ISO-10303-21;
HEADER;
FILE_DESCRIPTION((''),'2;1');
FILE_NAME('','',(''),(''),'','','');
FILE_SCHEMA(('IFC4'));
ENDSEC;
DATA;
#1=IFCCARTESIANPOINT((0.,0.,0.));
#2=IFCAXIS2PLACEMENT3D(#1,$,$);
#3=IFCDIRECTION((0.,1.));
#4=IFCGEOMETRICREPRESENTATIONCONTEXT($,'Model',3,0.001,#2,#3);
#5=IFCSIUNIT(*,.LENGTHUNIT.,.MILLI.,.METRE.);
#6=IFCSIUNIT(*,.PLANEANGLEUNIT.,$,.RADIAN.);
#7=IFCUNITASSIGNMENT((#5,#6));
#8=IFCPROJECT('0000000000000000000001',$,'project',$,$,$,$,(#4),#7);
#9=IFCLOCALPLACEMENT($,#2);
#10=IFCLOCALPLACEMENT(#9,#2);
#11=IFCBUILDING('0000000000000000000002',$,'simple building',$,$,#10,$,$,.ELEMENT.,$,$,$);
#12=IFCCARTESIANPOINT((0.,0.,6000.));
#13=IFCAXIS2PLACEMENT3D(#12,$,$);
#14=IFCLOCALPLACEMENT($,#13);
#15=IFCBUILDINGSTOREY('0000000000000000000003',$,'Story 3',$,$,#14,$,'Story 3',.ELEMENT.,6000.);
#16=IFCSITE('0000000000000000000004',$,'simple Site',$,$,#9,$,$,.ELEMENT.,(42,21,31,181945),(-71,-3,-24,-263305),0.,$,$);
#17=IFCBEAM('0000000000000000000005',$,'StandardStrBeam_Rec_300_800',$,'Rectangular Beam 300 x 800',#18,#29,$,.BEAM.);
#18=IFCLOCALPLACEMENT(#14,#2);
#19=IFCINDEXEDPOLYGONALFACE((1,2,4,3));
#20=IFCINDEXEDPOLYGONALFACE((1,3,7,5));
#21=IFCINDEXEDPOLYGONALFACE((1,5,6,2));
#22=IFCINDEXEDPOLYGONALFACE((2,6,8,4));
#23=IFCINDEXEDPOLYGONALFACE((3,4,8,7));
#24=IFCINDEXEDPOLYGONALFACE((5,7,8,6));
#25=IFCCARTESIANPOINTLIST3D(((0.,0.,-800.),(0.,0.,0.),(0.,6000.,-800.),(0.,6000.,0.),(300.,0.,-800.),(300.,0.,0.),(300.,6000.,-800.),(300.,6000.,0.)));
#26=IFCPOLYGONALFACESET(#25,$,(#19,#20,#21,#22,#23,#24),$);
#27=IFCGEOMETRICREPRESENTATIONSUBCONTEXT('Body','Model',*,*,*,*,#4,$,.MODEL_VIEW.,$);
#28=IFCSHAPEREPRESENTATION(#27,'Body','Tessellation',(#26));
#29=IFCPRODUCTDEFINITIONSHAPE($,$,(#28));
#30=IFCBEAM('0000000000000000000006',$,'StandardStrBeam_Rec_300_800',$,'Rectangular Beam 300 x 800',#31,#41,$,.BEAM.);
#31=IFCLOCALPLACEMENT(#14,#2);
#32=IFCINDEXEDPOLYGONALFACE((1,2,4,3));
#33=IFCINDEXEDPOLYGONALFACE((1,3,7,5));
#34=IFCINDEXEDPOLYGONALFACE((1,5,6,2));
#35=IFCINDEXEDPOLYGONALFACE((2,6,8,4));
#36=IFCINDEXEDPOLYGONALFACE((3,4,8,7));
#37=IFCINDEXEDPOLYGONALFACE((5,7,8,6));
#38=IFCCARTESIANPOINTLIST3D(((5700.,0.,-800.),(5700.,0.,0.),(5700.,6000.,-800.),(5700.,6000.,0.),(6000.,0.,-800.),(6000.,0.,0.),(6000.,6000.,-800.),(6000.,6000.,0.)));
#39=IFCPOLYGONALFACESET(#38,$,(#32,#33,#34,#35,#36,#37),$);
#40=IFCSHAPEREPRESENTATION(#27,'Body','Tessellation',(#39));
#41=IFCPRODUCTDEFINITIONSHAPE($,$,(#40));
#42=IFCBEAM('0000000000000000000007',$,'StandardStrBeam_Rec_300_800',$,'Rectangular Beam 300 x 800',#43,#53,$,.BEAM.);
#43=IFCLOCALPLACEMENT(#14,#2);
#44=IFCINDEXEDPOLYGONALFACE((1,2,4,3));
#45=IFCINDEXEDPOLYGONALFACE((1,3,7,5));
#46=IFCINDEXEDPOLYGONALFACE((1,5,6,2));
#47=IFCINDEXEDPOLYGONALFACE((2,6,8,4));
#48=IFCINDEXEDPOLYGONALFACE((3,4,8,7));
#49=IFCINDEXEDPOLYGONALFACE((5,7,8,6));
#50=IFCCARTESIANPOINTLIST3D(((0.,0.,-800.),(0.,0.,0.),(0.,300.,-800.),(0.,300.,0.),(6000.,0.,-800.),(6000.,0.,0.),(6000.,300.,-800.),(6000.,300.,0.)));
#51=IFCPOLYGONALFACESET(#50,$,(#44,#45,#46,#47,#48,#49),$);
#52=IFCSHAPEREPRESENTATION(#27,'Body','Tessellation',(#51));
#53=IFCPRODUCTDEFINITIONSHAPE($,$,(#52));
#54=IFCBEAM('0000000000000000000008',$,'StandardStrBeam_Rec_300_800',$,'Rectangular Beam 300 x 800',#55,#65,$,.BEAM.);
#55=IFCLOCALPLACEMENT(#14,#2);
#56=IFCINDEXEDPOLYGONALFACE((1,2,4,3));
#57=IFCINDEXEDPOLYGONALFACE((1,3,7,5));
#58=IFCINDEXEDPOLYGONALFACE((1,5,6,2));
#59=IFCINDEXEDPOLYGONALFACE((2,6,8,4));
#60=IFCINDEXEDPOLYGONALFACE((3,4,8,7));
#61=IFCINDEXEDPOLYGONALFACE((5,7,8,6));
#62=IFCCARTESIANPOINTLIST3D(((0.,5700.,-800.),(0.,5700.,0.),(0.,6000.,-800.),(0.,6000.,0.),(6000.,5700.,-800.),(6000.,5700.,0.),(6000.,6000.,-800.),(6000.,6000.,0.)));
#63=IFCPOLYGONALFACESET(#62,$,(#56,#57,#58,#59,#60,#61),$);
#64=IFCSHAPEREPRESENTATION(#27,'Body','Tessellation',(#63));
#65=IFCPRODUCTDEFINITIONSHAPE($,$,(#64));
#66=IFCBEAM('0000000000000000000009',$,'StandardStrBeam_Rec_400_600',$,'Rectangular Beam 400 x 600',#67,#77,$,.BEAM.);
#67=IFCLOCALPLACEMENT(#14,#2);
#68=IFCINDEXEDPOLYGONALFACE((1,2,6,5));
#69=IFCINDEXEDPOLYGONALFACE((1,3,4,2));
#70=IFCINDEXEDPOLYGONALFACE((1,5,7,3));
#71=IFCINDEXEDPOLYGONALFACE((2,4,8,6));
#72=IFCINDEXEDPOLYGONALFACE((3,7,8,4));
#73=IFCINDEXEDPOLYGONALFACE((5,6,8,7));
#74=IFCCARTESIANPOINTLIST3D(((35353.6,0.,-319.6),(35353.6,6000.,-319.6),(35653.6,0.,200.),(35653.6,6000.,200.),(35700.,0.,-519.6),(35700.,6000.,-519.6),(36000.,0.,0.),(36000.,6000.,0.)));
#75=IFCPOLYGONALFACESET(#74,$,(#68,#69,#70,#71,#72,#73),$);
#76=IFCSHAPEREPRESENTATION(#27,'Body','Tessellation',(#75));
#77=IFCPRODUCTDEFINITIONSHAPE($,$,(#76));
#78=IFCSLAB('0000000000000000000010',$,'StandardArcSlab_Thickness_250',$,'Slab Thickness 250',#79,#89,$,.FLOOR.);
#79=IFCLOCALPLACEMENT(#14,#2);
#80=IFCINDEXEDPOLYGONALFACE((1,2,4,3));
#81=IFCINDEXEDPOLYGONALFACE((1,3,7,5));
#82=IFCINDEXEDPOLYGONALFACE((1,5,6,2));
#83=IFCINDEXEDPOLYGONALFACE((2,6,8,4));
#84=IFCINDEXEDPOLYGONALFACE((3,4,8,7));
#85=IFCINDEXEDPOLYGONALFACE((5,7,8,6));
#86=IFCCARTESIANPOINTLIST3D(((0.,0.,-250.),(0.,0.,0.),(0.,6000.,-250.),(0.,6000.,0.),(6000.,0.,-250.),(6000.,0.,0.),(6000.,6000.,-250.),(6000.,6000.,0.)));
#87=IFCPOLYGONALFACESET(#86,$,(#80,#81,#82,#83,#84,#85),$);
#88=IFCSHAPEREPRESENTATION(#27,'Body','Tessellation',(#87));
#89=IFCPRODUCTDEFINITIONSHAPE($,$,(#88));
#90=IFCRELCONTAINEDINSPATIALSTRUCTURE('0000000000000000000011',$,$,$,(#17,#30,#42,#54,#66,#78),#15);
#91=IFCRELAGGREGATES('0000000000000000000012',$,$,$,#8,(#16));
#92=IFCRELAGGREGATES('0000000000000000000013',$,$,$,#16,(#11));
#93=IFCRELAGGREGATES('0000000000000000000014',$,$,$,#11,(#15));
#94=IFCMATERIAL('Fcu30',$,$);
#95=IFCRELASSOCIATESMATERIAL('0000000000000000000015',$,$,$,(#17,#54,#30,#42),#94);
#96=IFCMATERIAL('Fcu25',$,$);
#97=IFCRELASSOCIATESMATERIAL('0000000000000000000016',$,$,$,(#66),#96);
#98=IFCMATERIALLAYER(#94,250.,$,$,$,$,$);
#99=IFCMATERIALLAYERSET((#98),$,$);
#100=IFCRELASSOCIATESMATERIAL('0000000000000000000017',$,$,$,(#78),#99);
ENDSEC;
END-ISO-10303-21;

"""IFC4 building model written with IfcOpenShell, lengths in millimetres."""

from ifc_helpers import new_model, si_unit, direction, frame, origin, origin_with_axes, origin_2d_with_axis, place, context, subcontext, project, spatial, polyline, rectangle, outline, extrude, material, layer, layer_set, layer_usage, material_profile, profile_set, profile_usage, element, save


model = new_model("IFC4")

# Units and contexts
model_context = context("Model", 3, precision=0.001, world=origin(), true_north=direction((0.0, 1.0)))
body_context = subcontext(model_context, "Body", "Model", "MODEL_VIEW")
ifc_project = project(units=[si_unit("LENGTHUNIT", "METRE", prefix="MILLI"), si_unit("PLANEANGLEUNIT", "RADIAN")], contexts=[model_context])

# Site, building, storey
site_placement = place(None, origin())
site = spatial("IfcSite", under=ifc_project, at=site_placement, Name="simple Site", CompositionType="ELEMENT", RefLatitude=(42, 21, 31, 181945), RefLongitude=(-71, -3, -24, -263305), RefElevation=0.0)
building_placement = place(site_placement, origin())
building = spatial("IfcBuilding", under=site, at=building_placement, Name="simple building", CompositionType="ELEMENT")
storey_placement = place(None, frame((0.0, 0.0, 6000.0)))
storey = spatial("IfcBuildingStorey", under=building, at=storey_placement, Name="Story 3", LongName="Story 3", CompositionType="ELEMENT", Elevation=6000.0)

# Beams
ifc_material_1 = material(Name="Fcu30")
ifc_material_profile_1 = material_profile(ifc_material_1, rectangle(XDim=300.0, YDim=800.0, at=origin_2d_with_axis()))
ifc_profile_set_1 = profile_set([ifc_material_profile_1])
ifc_profile_usage_1 = profile_usage(ifc_profile_set_1, cardinal=7)
beam_1_placement = place(None, frame((150.0, 0.0, 5600.0), z_axis=(0.0, 1.0, 0.0), x_axis=(1.0, 0.0, 0.0)))
element("IfcBeam", 1, at=beam_1_placement, inside=storey, material=ifc_profile_usage_1, Name="StandardStrBeam_Rec_300_800", ObjectType="Rectangular Beam 300 x 800", PredefinedType="BEAM", context=body_context, shape_type="SweptSolid", body=[
    extrude(rectangle(XDim=300.0, YDim=800.0, at=origin_2d_with_axis()), origin_with_axes(), (0.0, 0.0, 1.0), 6000.0),
])
ifc_profile_usage_2 = profile_usage(ifc_profile_set_1, cardinal=9)
for number, where, z_axis, x_axis, name in (
    (2, (5850.0, 0.0, 5600.0), (0.0, 1.0, 0.0), (1.0, 0.0, 0.0), "StandardStrBeam_Rec_300_800"),
    (3, (0.0, 150.0, 5600.0), (1.0, 0.0, 0.0), (0.0, -1.0, 0.0), "StandardStrBeam_Rec_300_800"),
):
    element("IfcBeam", number, at=place(None, frame(where, z_axis=z_axis, x_axis=x_axis)), inside=storey, material=ifc_profile_usage_2, Name=name, ObjectType="Rectangular Beam 300 x 800", PredefinedType="BEAM", context=body_context, shape_type="SweptSolid", body=[
        extrude(rectangle(XDim=300.0, YDim=800.0, at=origin_2d_with_axis()), origin_with_axes(), (0.0, 0.0, 1.0), 6000.0),
    ])
beam_2_placement = place(None, frame((0.0, 5850.0, 5600.0), z_axis=(1.0, 0.0, 0.0), x_axis=(0.0, -1.0, 0.0)))
element("IfcBeam", 4, at=beam_2_placement, inside=storey, material=ifc_profile_usage_1, Name="StandardStrBeam_Rec_300_800", ObjectType="Rectangular Beam 300 x 800", PredefinedType="BEAM", context=body_context, shape_type="SweptSolid", body=[
    extrude(rectangle(XDim=300.0, YDim=800.0, at=origin_2d_with_axis()), origin_with_axes(), (0.0, 0.0, 1.0), 6000.0),
])
ifc_material_2 = material(Name="Fcu25")
ifc_material_profile_2 = material_profile(ifc_material_2, rectangle(XDim=400.0, YDim=600.0, at=origin_2d_with_axis()))
ifc_profile_set_2 = profile_set([ifc_material_profile_2])
ifc_profile_usage_3 = profile_usage(ifc_profile_set_2, cardinal=9)
beam_3_placement = place(None, frame((35676.8, 0.0, 5840.2), z_axis=(0.0, 1.0, 0.0), x_axis=(0.866025, 0.0, -0.5)))
element("IfcBeam", 5, at=beam_3_placement, inside=storey, material=ifc_profile_usage_3, Name="StandardStrBeam_Rec_400_600", ObjectType="Rectangular Beam 400 x 600", PredefinedType="BEAM", context=body_context, shape_type="SweptSolid", body=[
    extrude(rectangle(XDim=400.0, YDim=600.0, at=origin_2d_with_axis()), origin_with_axes(), (0.0, 0.0, 1.0), 6000.0),
])

# Slab
ifc_layer = layer(ifc_material_1, 250.0)
ifc_layer_set = layer_set([ifc_layer])
ifc_layer_usage = layer_usage(ifc_layer_set, "AXIS3", "POSITIVE", -250.0)
slab_placement = place(None, frame((0.0, 0.0, 5750.0), z_axis=(0.0, 0.0, 1.0), x_axis=(1.0, 0.0, 0.0)))
element("IfcSlab", 6, at=slab_placement, inside=storey, material=ifc_layer_usage, Name="StandardArcSlab_Thickness_250", ObjectType="Slab Thickness 250", PredefinedType="FLOOR", context=body_context, shape_type="SweptSolid", body=[
    extrude(outline(polyline([(0.0, 0.0), (6000.0, 0.0), (6000.0, 6000.0), (0.0, 6000.0), (0.0, 0.0)])), origin_with_axes(), (0.0, 0.0, 1.0), 250.0),
])

save(model, "model.ifc")
